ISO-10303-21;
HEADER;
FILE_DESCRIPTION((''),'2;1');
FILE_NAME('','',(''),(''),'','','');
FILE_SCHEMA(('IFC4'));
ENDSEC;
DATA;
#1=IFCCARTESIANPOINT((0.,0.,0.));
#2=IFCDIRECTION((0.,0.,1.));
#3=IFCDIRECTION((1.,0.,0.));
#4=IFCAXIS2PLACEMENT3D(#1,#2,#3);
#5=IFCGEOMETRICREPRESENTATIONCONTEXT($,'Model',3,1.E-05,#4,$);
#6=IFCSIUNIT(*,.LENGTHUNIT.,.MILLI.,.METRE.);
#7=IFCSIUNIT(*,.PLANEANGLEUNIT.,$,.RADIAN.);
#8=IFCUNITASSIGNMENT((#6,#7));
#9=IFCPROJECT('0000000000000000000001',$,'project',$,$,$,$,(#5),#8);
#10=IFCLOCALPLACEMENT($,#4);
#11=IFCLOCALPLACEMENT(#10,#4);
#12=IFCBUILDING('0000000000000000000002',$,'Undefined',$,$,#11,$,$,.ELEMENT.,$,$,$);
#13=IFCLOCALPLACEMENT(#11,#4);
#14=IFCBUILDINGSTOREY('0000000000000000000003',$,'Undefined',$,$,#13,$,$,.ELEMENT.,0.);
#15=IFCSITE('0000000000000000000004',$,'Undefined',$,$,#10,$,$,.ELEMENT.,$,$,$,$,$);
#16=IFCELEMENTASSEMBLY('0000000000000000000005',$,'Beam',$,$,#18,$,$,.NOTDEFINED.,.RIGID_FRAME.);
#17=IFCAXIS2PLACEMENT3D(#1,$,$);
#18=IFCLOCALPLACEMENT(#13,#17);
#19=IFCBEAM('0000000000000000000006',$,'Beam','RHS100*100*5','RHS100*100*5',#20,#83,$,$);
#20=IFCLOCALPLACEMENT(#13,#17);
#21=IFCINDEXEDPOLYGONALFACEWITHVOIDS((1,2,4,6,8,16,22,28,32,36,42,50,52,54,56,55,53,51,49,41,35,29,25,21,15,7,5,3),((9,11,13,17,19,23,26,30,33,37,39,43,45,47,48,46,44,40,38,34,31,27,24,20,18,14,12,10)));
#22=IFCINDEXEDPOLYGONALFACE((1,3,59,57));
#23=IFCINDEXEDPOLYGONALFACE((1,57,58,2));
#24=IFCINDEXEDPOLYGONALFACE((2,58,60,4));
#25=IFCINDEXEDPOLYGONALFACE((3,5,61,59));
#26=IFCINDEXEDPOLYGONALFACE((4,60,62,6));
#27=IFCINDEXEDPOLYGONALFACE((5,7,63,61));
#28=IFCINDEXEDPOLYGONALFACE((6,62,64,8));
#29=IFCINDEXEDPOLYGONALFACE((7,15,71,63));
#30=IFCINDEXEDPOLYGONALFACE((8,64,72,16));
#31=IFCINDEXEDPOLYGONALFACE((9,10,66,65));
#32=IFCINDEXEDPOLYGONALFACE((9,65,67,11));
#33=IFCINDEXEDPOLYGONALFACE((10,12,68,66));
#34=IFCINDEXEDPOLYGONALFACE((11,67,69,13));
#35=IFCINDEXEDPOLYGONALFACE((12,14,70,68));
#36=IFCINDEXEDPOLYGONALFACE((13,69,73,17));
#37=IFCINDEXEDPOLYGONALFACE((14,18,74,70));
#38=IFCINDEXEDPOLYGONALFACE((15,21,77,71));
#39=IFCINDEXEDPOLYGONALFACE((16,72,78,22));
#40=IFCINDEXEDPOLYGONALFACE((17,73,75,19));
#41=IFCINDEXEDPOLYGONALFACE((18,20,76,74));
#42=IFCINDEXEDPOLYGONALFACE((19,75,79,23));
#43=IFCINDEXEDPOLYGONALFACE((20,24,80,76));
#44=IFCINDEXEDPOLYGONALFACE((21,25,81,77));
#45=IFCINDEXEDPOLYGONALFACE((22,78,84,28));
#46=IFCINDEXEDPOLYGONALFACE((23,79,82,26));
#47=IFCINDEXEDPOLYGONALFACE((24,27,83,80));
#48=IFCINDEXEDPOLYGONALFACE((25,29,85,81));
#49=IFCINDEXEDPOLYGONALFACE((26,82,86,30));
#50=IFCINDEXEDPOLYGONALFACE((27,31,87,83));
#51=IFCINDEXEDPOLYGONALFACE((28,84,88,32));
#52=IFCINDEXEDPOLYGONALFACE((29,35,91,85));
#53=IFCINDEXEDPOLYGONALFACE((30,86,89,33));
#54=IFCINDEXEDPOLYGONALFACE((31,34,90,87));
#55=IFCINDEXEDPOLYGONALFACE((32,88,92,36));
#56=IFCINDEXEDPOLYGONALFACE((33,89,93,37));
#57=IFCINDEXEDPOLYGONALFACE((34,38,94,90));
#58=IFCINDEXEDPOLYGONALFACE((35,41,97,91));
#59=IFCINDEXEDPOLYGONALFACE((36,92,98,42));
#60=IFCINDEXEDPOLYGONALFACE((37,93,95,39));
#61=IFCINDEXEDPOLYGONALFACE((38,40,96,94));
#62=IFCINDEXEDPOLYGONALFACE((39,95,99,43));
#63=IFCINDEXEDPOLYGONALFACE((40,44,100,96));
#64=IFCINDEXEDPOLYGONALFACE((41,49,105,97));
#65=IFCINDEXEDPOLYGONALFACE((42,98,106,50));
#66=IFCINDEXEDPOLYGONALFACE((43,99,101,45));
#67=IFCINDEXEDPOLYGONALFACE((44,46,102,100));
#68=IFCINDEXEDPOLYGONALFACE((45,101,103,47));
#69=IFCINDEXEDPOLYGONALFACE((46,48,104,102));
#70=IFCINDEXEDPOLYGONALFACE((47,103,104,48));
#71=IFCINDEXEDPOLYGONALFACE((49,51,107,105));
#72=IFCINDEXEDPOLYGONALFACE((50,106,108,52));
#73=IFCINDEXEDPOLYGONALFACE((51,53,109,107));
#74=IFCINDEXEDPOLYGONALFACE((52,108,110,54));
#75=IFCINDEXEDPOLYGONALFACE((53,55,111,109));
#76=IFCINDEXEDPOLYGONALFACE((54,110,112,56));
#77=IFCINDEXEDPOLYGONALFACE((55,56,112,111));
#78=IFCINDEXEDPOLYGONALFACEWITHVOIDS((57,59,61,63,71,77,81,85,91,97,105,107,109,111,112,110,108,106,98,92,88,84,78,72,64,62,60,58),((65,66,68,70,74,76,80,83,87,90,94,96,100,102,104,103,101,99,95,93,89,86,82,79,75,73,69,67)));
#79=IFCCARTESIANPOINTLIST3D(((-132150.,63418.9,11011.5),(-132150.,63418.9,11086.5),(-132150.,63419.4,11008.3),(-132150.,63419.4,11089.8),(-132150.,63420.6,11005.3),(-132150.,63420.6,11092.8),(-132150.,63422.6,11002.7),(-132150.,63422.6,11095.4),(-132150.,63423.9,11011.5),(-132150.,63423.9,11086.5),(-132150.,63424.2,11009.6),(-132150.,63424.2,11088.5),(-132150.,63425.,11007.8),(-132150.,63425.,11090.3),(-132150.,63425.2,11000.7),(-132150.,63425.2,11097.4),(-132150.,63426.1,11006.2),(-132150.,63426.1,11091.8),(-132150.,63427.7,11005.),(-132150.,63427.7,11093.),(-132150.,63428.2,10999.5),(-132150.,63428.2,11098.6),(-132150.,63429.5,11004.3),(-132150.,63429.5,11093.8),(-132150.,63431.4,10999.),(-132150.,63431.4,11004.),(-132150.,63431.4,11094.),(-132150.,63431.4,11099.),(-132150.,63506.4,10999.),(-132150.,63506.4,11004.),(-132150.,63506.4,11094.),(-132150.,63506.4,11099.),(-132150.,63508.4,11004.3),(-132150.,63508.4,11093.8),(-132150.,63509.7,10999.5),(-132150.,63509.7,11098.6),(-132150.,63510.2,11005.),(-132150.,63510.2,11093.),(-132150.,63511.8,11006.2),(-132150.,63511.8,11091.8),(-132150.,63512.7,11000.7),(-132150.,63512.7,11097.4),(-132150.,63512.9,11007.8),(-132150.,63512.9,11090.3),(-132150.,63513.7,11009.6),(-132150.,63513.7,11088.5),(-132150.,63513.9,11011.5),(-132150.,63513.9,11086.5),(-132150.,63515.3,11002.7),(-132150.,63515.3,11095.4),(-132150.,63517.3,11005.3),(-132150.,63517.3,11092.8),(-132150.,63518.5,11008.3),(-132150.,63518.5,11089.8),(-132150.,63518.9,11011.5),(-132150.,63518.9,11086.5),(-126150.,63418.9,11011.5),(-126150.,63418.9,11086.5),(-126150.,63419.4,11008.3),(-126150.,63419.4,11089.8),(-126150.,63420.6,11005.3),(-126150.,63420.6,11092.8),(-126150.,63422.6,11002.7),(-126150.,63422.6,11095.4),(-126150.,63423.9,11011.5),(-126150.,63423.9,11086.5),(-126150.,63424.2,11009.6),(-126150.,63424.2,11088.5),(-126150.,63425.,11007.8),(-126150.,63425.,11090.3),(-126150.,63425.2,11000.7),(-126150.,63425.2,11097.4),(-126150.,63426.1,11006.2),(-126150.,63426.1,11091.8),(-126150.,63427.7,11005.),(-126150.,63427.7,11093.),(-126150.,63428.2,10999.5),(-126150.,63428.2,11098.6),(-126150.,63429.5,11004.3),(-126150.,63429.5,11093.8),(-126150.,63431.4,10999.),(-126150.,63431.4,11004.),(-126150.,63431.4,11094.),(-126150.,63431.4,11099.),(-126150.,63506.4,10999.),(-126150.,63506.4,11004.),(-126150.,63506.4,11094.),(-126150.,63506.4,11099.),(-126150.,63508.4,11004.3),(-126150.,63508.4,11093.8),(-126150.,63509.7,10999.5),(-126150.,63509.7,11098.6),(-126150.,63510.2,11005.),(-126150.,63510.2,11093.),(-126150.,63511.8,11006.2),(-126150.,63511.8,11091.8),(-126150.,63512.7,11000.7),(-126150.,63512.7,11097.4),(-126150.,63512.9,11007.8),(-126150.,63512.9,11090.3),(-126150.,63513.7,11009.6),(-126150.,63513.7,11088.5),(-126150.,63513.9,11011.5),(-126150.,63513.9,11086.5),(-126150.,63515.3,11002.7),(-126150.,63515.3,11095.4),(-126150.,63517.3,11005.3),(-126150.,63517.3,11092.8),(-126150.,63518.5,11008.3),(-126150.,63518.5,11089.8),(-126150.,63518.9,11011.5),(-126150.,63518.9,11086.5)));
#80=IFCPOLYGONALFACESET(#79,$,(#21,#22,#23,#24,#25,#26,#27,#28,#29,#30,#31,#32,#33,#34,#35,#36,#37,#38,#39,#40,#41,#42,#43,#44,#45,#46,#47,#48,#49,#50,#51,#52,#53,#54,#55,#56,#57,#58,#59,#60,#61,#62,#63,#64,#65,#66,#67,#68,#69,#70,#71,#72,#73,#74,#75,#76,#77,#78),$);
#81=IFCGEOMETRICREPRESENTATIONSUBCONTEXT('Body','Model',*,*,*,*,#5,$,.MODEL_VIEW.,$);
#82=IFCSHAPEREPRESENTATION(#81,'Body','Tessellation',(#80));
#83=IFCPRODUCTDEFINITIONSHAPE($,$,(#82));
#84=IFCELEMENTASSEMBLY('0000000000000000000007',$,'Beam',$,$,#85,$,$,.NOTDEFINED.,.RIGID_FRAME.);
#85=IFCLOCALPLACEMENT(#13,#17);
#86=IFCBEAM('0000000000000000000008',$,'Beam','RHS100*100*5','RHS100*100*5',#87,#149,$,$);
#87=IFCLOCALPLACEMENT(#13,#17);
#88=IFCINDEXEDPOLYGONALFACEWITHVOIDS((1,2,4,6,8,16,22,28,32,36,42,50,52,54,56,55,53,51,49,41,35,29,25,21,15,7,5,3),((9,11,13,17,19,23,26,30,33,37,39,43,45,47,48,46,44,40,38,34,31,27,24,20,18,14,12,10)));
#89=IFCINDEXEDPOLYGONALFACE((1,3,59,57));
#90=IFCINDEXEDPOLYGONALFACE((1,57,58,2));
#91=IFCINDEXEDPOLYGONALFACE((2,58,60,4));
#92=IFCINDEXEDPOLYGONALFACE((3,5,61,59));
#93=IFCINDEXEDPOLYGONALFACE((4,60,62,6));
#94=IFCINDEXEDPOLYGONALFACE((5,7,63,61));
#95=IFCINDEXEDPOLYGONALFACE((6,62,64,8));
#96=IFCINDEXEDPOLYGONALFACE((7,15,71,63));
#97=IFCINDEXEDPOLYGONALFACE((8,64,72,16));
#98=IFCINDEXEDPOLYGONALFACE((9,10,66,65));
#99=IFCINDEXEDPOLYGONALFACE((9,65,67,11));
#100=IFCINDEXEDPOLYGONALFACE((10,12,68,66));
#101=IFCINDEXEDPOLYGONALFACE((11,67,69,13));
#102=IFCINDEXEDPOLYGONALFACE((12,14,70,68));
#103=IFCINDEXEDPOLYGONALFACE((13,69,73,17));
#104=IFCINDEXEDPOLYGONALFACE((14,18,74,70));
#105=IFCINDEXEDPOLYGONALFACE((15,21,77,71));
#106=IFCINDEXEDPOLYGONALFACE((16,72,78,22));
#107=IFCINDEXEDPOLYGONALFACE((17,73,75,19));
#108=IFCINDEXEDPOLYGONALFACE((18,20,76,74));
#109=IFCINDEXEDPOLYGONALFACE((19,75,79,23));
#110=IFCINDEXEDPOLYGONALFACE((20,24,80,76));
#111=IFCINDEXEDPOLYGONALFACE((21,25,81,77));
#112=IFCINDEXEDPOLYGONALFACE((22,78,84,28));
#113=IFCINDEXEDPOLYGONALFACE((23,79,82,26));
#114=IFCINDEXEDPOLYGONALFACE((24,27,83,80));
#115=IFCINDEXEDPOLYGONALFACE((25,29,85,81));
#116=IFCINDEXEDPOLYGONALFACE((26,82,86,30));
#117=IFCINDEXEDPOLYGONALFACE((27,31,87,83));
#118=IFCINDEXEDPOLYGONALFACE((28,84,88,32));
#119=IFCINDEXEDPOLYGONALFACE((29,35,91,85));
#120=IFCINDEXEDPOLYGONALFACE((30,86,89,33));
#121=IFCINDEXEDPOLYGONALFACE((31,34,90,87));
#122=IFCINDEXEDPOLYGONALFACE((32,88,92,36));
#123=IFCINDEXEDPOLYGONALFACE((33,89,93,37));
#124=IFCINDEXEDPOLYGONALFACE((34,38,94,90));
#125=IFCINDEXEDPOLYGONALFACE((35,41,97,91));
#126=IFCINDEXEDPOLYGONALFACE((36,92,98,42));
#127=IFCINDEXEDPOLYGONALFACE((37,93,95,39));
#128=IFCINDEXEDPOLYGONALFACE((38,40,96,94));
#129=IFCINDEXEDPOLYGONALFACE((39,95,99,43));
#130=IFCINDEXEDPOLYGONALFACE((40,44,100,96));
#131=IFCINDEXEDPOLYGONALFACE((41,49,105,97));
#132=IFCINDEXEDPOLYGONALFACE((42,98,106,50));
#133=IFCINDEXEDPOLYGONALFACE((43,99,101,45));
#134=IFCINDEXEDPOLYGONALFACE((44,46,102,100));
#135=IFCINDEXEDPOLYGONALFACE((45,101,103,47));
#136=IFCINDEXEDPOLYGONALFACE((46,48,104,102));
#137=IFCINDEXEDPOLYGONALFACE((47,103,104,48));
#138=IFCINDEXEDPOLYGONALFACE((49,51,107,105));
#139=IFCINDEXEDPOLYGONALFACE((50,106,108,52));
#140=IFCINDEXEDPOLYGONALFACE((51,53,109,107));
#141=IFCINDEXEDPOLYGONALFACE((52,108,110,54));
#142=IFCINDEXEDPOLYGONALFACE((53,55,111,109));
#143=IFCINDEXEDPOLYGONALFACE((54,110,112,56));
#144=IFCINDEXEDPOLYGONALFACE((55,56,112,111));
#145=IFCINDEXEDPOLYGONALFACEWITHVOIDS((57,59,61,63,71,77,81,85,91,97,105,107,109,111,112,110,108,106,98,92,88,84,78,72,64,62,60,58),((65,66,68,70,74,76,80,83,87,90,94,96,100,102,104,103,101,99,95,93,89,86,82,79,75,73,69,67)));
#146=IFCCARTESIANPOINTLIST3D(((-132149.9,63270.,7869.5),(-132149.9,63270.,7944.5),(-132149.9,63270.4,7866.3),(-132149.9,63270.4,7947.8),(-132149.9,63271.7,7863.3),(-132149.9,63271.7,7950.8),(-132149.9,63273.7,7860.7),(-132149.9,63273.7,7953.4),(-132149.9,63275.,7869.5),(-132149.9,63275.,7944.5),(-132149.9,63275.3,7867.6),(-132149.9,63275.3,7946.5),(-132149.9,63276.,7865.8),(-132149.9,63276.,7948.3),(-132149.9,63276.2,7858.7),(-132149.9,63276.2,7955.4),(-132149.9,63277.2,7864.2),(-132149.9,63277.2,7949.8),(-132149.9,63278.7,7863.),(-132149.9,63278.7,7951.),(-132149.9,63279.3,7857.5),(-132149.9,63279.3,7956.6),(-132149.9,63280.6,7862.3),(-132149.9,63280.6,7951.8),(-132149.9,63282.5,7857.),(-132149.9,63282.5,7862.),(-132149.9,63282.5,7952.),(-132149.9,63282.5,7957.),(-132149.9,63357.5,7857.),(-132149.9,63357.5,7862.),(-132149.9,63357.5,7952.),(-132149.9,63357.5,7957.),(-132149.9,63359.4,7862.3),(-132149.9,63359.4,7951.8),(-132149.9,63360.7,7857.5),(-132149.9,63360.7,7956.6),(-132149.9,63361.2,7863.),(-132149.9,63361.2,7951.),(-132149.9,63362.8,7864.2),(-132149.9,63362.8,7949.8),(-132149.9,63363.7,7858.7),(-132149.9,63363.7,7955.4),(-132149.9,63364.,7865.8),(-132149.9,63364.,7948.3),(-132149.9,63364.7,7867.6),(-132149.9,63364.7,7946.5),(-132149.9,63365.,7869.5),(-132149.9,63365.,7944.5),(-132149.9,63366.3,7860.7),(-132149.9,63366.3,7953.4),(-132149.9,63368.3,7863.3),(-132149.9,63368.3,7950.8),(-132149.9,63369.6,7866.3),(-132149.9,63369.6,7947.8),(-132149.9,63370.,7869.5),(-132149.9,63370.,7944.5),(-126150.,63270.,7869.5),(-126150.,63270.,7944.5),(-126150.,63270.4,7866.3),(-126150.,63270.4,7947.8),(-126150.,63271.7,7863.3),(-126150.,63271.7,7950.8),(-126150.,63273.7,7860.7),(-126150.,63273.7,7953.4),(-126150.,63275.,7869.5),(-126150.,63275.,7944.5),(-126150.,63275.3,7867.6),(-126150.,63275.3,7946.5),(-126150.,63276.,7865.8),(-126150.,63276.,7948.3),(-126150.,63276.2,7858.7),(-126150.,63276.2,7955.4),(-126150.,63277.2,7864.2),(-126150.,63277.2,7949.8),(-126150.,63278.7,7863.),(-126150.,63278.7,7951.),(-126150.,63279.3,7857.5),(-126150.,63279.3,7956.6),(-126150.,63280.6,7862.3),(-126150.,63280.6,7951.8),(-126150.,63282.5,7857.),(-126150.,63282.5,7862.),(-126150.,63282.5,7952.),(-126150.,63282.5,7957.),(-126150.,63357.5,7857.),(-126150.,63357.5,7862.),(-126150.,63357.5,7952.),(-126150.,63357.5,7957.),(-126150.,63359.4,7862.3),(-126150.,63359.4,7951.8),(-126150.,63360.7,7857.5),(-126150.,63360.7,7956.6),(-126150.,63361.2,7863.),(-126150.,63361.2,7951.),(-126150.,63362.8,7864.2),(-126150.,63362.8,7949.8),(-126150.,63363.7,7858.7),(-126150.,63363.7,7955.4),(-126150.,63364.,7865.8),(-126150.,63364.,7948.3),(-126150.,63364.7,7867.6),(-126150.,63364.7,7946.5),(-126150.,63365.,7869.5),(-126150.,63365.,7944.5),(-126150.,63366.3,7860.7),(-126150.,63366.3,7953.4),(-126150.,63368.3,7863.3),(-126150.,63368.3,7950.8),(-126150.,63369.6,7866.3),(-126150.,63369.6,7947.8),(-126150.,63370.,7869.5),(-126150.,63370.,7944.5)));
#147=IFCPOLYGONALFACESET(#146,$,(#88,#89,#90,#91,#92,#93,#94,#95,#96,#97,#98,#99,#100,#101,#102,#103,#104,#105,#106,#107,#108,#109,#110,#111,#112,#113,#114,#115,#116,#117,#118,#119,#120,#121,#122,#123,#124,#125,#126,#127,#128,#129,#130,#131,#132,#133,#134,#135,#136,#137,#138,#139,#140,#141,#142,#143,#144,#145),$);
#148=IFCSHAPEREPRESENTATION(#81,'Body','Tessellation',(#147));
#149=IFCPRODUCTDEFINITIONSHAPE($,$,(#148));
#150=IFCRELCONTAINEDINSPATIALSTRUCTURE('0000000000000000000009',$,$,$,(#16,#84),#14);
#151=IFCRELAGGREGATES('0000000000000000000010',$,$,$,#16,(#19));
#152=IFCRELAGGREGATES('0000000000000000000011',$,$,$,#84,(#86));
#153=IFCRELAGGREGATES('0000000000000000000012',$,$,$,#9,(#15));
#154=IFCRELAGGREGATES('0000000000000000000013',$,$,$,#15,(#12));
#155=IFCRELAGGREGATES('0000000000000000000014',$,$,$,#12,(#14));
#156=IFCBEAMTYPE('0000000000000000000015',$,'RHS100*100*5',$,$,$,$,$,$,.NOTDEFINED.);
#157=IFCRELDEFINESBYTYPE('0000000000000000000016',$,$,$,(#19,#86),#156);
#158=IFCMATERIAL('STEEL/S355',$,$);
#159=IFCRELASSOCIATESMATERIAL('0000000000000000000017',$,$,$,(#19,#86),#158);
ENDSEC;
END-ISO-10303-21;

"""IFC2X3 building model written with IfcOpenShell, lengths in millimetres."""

from ifc_helpers import new_model, si_unit, frame, origin_with_axes, origin_2d_with_axis, place, context, subcontext, project, spatial, hollow_rectangle, extrude, material, type_object, element, aggregate, save


model = new_model("IFC2X3")

# Units and contexts
model_context = context("Model", 3, precision=1e-05, world=origin_with_axes())
body_context = subcontext(model_context, "Body", "Model", "MODEL_VIEW")
ifc_project = project(units=[si_unit("LENGTHUNIT", "METRE", prefix="MILLI"), si_unit("PLANEANGLEUNIT", "RADIAN")], contexts=[model_context])

# Site, building, storey
site_placement = place(None, origin_with_axes())
site = spatial("IfcSite", under=ifc_project, at=site_placement, Name="Undefined", CompositionType="ELEMENT")
building_placement = place(site_placement, origin_with_axes())
building = spatial("IfcBuilding", under=site, at=building_placement, Name="Undefined", CompositionType="ELEMENT")
storey_placement = place(building_placement, origin_with_axes())
storey = spatial("IfcBuildingStorey", under=building, at=storey_placement, Name="Undefined", CompositionType="ELEMENT", Elevation=0.0)

# Element assemblies, beams
ifc_material_1 = material(Name="STEEL/S355")
assembly_1_placement = place(storey_placement, origin_with_axes())
assembly_1 = element("IfcElementAssembly", 1, at=assembly_1_placement, inside=storey, Name="Beam", AssemblyPlace="NOTDEFINED", PredefinedType="RIGID_FRAME")
beam_type_1 = type_object("IfcBeamType", Name="RHS100*100*5", PredefinedType="NOTDEFINED")
beam_1_placement = place(assembly_1_placement, frame((-126150.0, 63468.9, 11049.0), z_axis=(0.0, 0.0, 1.0), x_axis=(-1.0, 0.0, 0.0)))
beam_1 = element("IfcBeam", 2, at=beam_1_placement, type_object=beam_type_1, material=ifc_material_1, Name="Beam", Description="RHS100*100*5", ObjectType="RHS100*100*5", context=body_context, shape_type="SweptSolid", body=[
    extrude(hollow_rectangle(XDim=100.0, YDim=100.0, WallThickness=5.0, InnerFilletRadius=7.5, OuterFilletRadius=12.5, at=origin_2d_with_axis()), frame((6000.0, 0.0, 0.0), z_axis=(-1.0, 0.0, 0.0), x_axis=(0.0, -1.0, 0.0)), (0.0, 0.0, 1.0), 6000.0),
])
aggregate(assembly_1, [beam_1])
assembly_2_placement = place(storey_placement, origin_with_axes())
assembly_2 = element("IfcElementAssembly", 3, at=assembly_2_placement, inside=storey, Name="Beam", AssemblyPlace="NOTDEFINED", PredefinedType="RIGID_FRAME")
beam_2_placement = place(assembly_2_placement, frame((-126150.0, 63320.0, 7907.0), z_axis=(0.0, 0.0, 1.0), x_axis=(-1.0, 0.0, 0.0)))
beam_2 = element("IfcBeam", 4, at=beam_2_placement, type_object=beam_type_1, material=ifc_material_1, Name="Beam", Description="RHS100*100*5", ObjectType="RHS100*100*5", context=body_context, shape_type="SweptSolid", body=[
    extrude(hollow_rectangle(XDim=100.0, YDim=100.0, WallThickness=5.0, InnerFilletRadius=7.5, OuterFilletRadius=12.5, at=origin_2d_with_axis()), frame((5999.9, 0.0, 0.0), z_axis=(-1.0, 0.0, 0.0), x_axis=(0.0, -1.0, 0.0)), (0.0, 0.0, 1.0), 5999.9),
])
aggregate(assembly_2, [beam_2])

save(model, "model.ifc")
